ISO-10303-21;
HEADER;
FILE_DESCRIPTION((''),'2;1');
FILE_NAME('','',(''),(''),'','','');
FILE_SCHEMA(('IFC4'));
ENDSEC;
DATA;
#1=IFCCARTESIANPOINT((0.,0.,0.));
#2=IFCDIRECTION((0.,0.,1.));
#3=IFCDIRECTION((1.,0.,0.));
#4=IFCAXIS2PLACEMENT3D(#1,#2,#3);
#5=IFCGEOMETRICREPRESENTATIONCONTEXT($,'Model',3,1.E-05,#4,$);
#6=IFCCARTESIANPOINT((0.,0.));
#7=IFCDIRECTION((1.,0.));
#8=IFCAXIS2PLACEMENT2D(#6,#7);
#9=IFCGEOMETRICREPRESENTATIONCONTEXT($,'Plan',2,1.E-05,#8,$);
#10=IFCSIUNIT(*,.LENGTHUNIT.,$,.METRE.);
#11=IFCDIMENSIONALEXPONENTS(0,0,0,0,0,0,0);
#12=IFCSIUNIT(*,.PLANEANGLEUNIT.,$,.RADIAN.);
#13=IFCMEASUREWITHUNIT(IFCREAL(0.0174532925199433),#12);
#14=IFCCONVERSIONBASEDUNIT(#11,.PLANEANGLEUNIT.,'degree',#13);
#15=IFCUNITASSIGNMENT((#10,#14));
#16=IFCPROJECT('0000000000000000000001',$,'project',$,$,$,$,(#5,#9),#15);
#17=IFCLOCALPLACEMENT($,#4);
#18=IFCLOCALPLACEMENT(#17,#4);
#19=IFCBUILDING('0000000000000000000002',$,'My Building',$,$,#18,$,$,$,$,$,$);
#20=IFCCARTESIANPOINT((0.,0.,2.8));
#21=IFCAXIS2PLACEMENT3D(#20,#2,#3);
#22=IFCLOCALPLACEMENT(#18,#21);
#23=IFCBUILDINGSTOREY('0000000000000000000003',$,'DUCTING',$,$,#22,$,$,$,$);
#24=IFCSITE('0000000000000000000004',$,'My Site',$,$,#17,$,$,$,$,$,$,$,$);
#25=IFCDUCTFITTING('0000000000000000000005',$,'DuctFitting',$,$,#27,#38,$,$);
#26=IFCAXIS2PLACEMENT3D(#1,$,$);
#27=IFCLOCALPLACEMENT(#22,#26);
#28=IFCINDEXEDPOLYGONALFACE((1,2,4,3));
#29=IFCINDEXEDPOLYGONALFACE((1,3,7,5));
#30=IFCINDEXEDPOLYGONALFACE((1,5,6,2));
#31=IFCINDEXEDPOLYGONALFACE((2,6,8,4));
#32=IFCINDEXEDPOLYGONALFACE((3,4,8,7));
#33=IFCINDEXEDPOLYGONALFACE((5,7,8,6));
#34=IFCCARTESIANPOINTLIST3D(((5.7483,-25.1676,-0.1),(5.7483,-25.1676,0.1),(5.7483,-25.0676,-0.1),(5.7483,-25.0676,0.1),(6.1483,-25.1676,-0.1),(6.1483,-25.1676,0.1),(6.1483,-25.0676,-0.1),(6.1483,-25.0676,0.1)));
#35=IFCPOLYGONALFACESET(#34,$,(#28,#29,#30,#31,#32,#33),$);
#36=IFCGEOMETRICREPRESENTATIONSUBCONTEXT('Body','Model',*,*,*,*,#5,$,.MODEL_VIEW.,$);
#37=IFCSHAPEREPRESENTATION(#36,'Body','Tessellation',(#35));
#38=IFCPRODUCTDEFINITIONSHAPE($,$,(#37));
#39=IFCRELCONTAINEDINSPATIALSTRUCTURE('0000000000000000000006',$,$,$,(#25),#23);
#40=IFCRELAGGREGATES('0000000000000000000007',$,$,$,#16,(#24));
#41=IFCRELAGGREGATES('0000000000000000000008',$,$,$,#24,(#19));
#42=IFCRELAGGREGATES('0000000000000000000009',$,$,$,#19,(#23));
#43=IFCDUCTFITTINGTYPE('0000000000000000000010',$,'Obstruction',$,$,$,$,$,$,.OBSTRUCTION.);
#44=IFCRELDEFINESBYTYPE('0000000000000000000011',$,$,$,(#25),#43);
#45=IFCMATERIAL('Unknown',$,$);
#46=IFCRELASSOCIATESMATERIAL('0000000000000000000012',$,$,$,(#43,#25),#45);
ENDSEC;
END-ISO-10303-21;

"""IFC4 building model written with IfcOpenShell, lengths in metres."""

from ifc_helpers import new_model, entity, si_unit, converted_unit, frame, origin_with_axes, origin_2d_with_axis, place, context, subcontext, project, spatial, rectangle, extrude, material, material_profile, profile_set, profile_usage, type_object, element, save


model = new_model("IFC4")

# Units and contexts
model_context = context("Model", 3, precision=1e-05, world=origin_with_axes())
plan_context = context("Plan", 2, precision=1e-05, world=origin_2d_with_axis())
body_context = subcontext(model_context, "Body", "Model", "MODEL_VIEW")
ifc_project = project(units=[si_unit("LENGTHUNIT", "METRE"), converted_unit("PLANEANGLEUNIT", "degree", entity("IfcReal", 0.0174532925199433), si_unit("PLANEANGLEUNIT", "RADIAN"), dimensions=[0, 0, 0, 0, 0, 0, 0])], contexts=[model_context, plan_context])

# Site, building, storey
site_placement = place(None, origin_with_axes())
site = spatial("IfcSite", under=ifc_project, at=site_placement, Name="My Site")
building_placement = place(site_placement, origin_with_axes())
building = spatial("IfcBuilding", under=site, at=building_placement, Name="My Building")
storey_placement = place(building_placement, frame((0.0, 0.0, 2.8), z_axis=(0.0, 0.0, 1.0), x_axis=(1.0, 0.0, 0.0)))
storey = spatial("IfcBuildingStorey", under=building, at=storey_placement, Name="DUCTING")

# Shared definitions
ifc_material = material(Name="Unknown")

# Duct fitting
ifc_material_profile_1 = material_profile(ifc_material, rectangle(XDim=0.4, YDim=0.2))
ifc_profile_set_1 = profile_set([ifc_material_profile_1])
duct_fitting_type_1 = type_object("IfcDuctFittingType", Name="Obstruction", PredefinedType="OBSTRUCTION", material=ifc_profile_set_1)
ifc_profile_usage_1 = profile_usage(ifc_profile_set_1, cardinal=5)
duct_fitting_1_placement = place(storey_placement, frame((5.9483, -25.0676, 0.0), z_axis=(0.0, -1.0, 0.0), x_axis=(1.0, 0.0, 0.0)))
element("IfcDuctFitting", 1, at=duct_fitting_1_placement, inside=storey, type_object=duct_fitting_type_1, material=ifc_profile_usage_1, Name="DuctFitting", context=body_context, shape_type="SweptSolid", body=[
    extrude(rectangle(XDim=0.4, YDim=0.2), origin_with_axes(), (0.0, 0.0, 1.0), 0.1),
])

save(model, "model.ifc")
